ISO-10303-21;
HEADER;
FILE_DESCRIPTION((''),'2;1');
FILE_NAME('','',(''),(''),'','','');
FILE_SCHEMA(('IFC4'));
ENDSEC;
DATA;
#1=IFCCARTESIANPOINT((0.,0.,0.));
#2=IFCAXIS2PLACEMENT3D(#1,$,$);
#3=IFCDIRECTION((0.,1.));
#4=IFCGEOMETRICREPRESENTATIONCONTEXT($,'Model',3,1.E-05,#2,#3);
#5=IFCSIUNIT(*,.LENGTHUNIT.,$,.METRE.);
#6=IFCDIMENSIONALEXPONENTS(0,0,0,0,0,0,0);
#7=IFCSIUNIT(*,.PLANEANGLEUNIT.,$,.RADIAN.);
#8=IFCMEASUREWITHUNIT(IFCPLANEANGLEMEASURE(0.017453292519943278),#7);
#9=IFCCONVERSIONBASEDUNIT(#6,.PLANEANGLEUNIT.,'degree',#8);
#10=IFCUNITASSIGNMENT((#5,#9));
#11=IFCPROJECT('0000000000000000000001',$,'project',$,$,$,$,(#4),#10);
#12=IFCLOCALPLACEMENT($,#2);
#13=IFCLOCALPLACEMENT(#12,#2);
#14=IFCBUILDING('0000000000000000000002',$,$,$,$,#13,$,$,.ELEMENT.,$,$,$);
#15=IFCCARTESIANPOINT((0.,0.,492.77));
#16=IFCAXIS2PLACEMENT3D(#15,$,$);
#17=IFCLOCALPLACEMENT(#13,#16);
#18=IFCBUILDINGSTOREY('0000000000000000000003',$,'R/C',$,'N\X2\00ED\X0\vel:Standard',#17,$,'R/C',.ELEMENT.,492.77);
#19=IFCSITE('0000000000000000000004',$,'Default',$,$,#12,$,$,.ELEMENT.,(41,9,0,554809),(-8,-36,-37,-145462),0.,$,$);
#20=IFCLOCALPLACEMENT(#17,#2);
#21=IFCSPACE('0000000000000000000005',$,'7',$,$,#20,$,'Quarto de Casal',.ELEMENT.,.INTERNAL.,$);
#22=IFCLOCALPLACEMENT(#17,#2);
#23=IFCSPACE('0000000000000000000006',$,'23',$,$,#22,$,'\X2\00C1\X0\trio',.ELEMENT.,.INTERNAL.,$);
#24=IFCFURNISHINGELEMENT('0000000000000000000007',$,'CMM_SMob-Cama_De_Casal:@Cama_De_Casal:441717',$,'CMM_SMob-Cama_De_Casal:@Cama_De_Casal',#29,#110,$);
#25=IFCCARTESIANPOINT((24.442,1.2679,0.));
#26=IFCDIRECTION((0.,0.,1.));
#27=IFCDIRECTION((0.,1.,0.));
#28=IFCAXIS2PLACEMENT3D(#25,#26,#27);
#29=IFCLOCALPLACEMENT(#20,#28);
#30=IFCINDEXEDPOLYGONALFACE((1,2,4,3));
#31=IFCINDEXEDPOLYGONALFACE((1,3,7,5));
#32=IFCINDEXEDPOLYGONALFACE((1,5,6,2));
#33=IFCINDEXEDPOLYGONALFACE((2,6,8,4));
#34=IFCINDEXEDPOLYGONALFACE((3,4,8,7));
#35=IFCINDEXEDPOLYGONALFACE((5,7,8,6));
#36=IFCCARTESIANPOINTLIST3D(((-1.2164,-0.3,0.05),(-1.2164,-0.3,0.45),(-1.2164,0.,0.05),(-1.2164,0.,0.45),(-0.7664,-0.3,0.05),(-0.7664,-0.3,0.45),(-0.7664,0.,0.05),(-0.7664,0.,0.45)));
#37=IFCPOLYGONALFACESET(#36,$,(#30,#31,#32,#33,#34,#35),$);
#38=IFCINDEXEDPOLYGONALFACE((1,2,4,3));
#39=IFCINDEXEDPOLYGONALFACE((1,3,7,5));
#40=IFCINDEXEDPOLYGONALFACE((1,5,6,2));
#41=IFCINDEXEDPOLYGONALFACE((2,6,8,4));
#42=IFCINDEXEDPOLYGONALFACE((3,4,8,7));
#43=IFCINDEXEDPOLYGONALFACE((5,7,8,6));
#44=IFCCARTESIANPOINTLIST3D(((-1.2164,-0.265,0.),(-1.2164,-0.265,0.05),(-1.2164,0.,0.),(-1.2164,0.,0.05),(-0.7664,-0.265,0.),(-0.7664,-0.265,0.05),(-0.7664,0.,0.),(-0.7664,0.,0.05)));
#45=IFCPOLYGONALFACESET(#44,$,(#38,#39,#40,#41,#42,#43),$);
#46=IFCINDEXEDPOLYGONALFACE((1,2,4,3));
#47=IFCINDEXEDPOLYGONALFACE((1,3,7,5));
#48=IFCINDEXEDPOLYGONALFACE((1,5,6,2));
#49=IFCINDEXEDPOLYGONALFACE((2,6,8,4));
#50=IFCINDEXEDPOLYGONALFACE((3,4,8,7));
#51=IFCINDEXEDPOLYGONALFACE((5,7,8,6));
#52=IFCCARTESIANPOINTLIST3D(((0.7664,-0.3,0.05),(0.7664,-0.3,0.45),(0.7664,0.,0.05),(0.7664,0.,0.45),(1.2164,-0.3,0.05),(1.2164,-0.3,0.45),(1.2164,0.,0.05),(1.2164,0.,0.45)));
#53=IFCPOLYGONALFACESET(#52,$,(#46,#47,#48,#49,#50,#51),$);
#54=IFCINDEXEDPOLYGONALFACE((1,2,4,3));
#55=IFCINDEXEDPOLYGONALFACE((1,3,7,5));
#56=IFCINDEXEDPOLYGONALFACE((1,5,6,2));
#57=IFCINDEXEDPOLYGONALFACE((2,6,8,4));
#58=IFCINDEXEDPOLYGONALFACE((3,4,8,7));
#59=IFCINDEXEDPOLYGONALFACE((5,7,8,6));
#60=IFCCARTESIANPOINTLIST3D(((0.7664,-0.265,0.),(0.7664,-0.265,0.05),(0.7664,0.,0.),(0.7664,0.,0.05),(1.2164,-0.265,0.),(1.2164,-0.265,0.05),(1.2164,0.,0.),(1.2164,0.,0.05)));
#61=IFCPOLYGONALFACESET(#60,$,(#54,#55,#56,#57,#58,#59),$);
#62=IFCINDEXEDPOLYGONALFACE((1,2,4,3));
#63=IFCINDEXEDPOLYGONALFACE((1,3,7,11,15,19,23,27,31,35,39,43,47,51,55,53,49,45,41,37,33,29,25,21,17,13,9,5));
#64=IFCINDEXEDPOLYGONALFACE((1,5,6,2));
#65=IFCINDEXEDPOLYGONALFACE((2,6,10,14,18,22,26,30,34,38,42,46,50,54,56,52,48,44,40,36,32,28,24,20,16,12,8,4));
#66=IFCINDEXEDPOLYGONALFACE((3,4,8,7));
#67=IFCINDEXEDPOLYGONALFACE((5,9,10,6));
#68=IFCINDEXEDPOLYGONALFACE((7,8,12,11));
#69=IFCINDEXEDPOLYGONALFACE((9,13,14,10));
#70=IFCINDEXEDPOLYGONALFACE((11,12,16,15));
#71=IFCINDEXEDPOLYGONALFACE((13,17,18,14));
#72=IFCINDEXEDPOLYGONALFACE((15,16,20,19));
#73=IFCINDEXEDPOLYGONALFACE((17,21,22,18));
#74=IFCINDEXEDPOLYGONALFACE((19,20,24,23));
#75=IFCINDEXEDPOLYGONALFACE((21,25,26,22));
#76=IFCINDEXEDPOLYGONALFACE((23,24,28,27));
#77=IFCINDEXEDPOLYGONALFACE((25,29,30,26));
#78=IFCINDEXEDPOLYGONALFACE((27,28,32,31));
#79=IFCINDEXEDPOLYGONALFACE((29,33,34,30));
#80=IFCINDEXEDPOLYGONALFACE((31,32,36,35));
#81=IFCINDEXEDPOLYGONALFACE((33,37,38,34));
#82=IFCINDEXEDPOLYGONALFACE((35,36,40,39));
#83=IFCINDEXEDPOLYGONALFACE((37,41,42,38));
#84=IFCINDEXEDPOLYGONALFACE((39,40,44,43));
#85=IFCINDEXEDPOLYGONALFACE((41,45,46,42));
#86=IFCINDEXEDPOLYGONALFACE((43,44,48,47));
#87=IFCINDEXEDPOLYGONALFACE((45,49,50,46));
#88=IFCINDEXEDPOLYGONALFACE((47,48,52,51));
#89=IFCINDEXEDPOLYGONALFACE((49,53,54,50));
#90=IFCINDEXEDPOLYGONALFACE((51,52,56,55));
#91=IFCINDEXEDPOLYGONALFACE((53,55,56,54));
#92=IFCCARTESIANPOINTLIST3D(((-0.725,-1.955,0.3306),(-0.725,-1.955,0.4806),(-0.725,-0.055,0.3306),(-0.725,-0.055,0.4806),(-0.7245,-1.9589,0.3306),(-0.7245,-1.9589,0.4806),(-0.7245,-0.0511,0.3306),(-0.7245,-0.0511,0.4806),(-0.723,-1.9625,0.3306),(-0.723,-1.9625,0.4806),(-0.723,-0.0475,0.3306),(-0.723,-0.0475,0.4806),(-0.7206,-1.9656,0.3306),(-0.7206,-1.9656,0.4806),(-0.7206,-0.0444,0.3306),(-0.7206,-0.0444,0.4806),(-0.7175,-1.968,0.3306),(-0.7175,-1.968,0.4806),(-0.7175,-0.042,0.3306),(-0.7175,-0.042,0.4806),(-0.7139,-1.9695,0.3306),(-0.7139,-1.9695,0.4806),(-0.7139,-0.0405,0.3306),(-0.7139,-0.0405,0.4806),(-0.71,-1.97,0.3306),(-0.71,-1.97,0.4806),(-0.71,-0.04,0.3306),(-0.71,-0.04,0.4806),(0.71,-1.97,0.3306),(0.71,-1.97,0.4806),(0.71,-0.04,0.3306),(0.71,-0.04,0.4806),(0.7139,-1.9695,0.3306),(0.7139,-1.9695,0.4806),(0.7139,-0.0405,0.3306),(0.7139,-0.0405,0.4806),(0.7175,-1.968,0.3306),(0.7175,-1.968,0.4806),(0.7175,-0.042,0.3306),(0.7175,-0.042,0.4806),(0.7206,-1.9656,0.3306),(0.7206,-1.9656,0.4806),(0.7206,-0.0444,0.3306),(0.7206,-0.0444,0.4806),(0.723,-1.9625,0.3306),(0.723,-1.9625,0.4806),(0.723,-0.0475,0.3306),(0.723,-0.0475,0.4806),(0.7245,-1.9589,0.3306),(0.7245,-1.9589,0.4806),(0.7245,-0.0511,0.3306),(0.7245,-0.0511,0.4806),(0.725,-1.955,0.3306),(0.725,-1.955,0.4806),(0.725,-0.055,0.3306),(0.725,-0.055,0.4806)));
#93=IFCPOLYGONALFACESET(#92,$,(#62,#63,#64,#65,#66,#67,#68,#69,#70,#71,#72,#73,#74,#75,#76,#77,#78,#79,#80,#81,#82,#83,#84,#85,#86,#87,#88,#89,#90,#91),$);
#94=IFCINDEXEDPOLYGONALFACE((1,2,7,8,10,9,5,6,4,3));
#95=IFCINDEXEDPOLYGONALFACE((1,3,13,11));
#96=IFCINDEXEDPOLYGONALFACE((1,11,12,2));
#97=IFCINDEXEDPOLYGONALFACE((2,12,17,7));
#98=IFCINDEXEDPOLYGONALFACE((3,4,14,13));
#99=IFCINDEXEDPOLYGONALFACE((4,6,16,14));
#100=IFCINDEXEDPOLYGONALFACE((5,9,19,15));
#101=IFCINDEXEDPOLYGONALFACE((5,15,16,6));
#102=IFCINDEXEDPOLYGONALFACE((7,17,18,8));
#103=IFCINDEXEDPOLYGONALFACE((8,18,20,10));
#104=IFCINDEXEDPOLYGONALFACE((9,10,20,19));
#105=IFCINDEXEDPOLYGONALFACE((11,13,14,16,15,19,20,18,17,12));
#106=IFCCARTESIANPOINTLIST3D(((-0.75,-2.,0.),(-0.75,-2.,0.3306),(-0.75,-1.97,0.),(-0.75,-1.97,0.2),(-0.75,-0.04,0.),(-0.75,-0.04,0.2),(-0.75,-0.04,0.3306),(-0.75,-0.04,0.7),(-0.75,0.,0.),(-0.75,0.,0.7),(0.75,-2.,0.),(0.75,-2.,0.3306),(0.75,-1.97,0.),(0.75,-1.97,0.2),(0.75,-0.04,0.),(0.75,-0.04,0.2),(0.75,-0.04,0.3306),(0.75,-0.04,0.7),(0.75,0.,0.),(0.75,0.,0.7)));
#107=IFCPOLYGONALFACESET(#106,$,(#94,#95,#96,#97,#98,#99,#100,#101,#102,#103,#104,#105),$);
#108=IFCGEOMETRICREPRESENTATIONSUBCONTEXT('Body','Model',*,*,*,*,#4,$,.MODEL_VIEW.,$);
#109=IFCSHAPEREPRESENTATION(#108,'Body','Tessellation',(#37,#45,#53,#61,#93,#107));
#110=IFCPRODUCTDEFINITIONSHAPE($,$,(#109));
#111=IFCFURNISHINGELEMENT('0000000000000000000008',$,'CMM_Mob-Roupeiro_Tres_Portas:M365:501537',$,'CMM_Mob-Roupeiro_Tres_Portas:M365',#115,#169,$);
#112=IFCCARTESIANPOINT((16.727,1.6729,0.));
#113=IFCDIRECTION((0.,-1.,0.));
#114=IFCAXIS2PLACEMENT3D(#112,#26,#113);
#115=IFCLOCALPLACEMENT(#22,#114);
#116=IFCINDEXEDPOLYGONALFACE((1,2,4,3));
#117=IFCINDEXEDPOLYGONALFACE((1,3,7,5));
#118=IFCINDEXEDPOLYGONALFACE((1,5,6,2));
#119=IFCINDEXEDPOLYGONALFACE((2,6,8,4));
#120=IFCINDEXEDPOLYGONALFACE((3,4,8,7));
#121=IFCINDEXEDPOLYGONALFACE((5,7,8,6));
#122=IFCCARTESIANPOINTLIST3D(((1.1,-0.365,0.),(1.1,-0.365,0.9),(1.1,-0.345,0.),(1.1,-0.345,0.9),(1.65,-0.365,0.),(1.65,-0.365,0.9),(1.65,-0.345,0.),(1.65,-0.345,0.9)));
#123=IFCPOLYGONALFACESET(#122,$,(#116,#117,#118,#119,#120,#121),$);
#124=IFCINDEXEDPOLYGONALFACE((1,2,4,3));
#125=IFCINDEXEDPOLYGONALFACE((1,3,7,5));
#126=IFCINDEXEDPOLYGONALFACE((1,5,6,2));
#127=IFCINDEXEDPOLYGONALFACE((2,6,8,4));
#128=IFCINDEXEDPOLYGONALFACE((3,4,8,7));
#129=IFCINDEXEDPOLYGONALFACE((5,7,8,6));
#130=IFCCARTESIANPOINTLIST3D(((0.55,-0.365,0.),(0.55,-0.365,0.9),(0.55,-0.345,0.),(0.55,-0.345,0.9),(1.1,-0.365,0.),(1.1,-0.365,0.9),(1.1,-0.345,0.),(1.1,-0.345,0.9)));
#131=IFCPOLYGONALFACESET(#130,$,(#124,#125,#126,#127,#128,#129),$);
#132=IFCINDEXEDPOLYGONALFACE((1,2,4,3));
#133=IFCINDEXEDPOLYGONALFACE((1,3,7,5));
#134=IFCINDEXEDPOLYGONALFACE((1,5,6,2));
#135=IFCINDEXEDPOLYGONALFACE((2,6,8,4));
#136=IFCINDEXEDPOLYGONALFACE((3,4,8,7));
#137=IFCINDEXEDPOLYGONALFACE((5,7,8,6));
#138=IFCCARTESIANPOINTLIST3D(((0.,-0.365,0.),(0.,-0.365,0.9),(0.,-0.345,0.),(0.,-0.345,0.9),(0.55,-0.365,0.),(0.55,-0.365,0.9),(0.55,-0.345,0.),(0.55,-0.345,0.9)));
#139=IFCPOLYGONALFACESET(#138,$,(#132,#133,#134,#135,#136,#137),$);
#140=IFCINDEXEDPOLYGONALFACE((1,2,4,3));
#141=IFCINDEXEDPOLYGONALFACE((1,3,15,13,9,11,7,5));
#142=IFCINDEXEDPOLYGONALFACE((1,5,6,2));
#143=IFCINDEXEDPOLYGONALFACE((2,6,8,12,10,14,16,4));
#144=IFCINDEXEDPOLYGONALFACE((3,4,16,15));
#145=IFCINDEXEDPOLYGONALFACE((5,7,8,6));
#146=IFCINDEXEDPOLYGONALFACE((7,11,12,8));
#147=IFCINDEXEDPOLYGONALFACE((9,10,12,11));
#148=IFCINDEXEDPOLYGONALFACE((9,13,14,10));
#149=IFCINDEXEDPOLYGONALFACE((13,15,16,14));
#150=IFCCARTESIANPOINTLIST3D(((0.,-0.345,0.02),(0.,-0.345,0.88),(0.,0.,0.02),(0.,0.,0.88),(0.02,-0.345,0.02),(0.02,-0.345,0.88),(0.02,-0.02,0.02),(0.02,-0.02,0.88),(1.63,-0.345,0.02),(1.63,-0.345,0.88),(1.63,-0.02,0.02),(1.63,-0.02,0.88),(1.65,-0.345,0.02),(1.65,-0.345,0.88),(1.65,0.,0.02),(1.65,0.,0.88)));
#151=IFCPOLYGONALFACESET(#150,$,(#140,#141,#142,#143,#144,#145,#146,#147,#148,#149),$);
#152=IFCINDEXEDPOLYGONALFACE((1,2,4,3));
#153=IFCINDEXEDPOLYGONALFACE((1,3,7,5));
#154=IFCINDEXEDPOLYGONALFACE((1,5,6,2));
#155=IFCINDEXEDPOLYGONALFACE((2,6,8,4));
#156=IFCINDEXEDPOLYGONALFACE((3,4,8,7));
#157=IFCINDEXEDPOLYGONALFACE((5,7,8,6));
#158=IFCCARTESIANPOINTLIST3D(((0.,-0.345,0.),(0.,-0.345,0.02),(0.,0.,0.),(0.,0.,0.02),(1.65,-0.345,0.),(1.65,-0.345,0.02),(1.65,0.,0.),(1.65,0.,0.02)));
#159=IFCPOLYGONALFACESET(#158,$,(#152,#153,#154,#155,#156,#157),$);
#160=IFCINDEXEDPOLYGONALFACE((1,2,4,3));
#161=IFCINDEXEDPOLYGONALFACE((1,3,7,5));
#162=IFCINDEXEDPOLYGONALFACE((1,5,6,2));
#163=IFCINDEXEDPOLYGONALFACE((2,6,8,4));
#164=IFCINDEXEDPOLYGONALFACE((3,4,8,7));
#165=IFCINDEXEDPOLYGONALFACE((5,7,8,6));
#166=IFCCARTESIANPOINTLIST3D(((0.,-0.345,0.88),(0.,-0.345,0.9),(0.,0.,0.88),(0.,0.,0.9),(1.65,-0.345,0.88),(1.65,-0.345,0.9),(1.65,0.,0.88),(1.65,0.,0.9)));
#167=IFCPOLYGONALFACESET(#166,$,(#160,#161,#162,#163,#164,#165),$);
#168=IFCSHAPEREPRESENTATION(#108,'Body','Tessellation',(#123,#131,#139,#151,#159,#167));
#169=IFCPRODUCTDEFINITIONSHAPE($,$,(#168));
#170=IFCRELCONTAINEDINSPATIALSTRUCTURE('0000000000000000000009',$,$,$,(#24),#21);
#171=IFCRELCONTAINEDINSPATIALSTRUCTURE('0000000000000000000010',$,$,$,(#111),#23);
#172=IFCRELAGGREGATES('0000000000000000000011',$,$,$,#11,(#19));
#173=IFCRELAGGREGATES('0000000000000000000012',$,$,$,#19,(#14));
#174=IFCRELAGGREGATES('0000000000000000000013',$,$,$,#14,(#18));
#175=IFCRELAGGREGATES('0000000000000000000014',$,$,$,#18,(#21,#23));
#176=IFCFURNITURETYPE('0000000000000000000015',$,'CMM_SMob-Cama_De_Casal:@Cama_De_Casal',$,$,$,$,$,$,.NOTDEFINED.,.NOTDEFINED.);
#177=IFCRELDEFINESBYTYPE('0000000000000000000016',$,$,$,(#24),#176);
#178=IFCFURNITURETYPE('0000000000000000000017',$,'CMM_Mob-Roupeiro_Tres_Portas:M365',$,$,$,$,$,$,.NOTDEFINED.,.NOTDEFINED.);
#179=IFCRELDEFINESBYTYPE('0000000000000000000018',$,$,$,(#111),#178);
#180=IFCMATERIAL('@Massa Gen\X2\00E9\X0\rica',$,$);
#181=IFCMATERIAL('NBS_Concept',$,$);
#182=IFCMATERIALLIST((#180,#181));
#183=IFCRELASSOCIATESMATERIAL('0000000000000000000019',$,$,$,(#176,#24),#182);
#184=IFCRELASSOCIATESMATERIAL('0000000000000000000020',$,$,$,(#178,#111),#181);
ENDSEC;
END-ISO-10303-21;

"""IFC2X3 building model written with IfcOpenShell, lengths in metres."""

from ifc_helpers import new_model, entity, si_unit, converted_unit, direction, frame, frame_2d, origin, origin_2d_with_axis, place, context, subcontext, project, spatial, polyline, circle_curve, parameter, trimmed, segment, composite_curve, rectangle, outline, extrude, source, transform, mapped, material, material_list, type_object, type_shapes, element, save


model = new_model("IFC2X3")

# Units and contexts
model_context = context("Model", 3, precision=1e-05, world=origin(), true_north=direction((0.0, 1.0)))
body_context = subcontext(model_context, "Body", "Model", "MODEL_VIEW")
ifc_project = project(units=[si_unit("LENGTHUNIT", "METRE"), converted_unit("PLANEANGLEUNIT", "degree", entity("IfcPlaneAngleMeasure", 0.017453292519943278), si_unit("PLANEANGLEUNIT", "RADIAN"), dimensions=[0, 0, 0, 0, 0, 0, 0])], contexts=[model_context])

# Site, building, storey
site_placement = place(None, origin())
site = spatial("IfcSite", under=ifc_project, at=site_placement, Name="Default", CompositionType="ELEMENT", RefLatitude=(41, 9, 0, 554809), RefLongitude=(-8, -36, -37, -145462), RefElevation=0.0)
building_placement = place(site_placement, origin())
building = spatial("IfcBuilding", under=site, at=building_placement, CompositionType="ELEMENT")
storey_placement = place(building_placement, frame((0.0, 0.0, 492.77)))
storey = spatial("IfcBuildingStorey", under=building, at=storey_placement, Name="R/C", ObjectType="Nível:Standard", LongName="R/C", CompositionType="ELEMENT", Elevation=492.77)

# Shared definitions
ifc_material_1 = material(Name="NBS_Concept")

# Shared definitions
space_1_placement = place(storey_placement, origin())
space_1 = spatial("IfcSpace", under=storey, at=space_1_placement, Name="7", LongName="Quarto de Casal", CompositionType="ELEMENT", InteriorOrExteriorSpace="INTERNAL")

# Furnishing element
ifc_material_2 = material(Name="@Massa Genérica")
ifc_material_list = material_list([ifc_material_2, ifc_material_1])
furniture_type_1 = type_object("IfcFurnitureType", Name="CMM_SMob-Cama_De_Casal:@Cama_De_Casal", AssemblyPlace="NOTDEFINED", material=ifc_material_list)
shared_shape_1 = source(origin(), body_context, "Body", "SweptSolid", [
    extrude(rectangle(XDim=0.3, YDim=0.45, at=frame_2d((0.0, 0.0), x_axis=(1.0, 0.0))), frame((-0.9914, -0.15, 0.05), z_axis=(0.0, 0.0, 1.0), x_axis=(0.0, 1.0, 0.0)), (0.0, 0.0, 1.0), 0.4),
    extrude(rectangle(XDim=0.265, YDim=0.45, at=frame_2d((0.0, 0.0), x_axis=(1.0, 0.0))), frame((-0.9914, -0.1325, 0.0), z_axis=(0.0, 0.0, 1.0), x_axis=(0.0, -1.0, 0.0)), (0.0, 0.0, 1.0), 0.05),
    extrude(rectangle(XDim=0.45, YDim=0.3, at=frame_2d((0.0, 0.0), x_axis=(1.0, 0.0))), frame((0.9914, -0.15, 0.05)), (0.0, 0.0, 1.0), 0.4),
    extrude(rectangle(XDim=0.45, YDim=0.265, at=origin_2d_with_axis()), frame((0.9914, -0.1325, 0.0), z_axis=(0.0, 0.0, 1.0), x_axis=(-1.0, 0.0, 0.0)), (0.0, 0.0, 1.0), 0.05),
    extrude(outline(composite_curve([segment(polyline([(-0.71, -0.965), (0.71, -0.965)]), True, "CONTINUOUS"), segment(trimmed(circle_curve(frame_2d((0.71, -0.95), x_axis=(-1.0, 0.0)), 0.015), [parameter(90.0)], [parameter(180.0)], True, "PARAMETER"), True, "CONTINUOUS"), segment(polyline([(0.725, -0.95), (0.725, 0.95)]), True, "CONTINUOUS"), segment(trimmed(circle_curve(frame_2d((0.71, 0.95), x_axis=(-1.0, 0.0)), 0.015), [parameter(180.0)], [parameter(270.0)], True, "PARAMETER"), True, "CONTINUOUS"), segment(polyline([(0.71, 0.965), (-0.71, 0.965)]), True, "CONTINUOUS"), segment(trimmed(circle_curve(frame_2d((-0.71, 0.95), x_axis=(-1.0, 0.0)), 0.015), [parameter(270.0)], [parameter(0.0)], True, "PARAMETER"), True, "CONTINUOUS"), segment(polyline([(-0.725, 0.95), (-0.725, -0.95)]), True, "CONTINUOUS"), segment(trimmed(circle_curve(frame_2d((-0.71, -0.95), x_axis=(-1.0, 0.0)), 0.015), [parameter(0.0)], [parameter(90.0)], True, "PARAMETER"), True, "CONTINUOUS")], self_intersect=False)), frame((0.0, -1.005, 0.3306), z_axis=(0.0, 0.0, 1.0), x_axis=(-1.0, 0.0, 0.0)), (0.0, 0.0, 1.0), 0.15),
    extrude(outline(polyline([(-0.2461, -1.16), (-0.2461, -1.19), (0.0845, -1.19), (0.0845, 0.77), (0.4539, 0.77), (0.4539, 0.81), (-0.2461, 0.81), (-0.2461, 0.77), (-0.0461, 0.77), (-0.0461, -1.16), (-0.2461, -1.16)])), frame((-0.75, -0.81, 0.2461), z_axis=(-1.0, 0.0, 0.0), x_axis=(0.0, 0.0, 1.0)), (0.0, 0.0, -1.0), 1.5),
])
type_shapes(furniture_type_1, [shared_shape_1])
furnishing_1_placement = place(space_1_placement, frame((24.442, 1.2679, 0.0), z_axis=(0.0, 0.0, 1.0), x_axis=(0.0, 1.0, 0.0)))
element("IfcFurnishingElement", 1, at=furnishing_1_placement, inside=space_1, type_object=furniture_type_1, material=ifc_material_list, Name="CMM_SMob-Cama_De_Casal:@Cama_De_Casal:441717", ObjectType="CMM_SMob-Cama_De_Casal:@Cama_De_Casal", context=body_context, shape_type="MappedRepresentation", body=[
    mapped(shared_shape_1, transform((0.0, 0.0, 0.0), scale=1.0)),
])

# Shared definitions
space_2_placement = place(storey_placement, origin())
space_2 = spatial("IfcSpace", under=storey, at=space_2_placement, Name="23", LongName="Átrio", CompositionType="ELEMENT", InteriorOrExteriorSpace="INTERNAL")

# Furnishing element
furniture_type_2 = type_object("IfcFurnitureType", Name="CMM_Mob-Roupeiro_Tres_Portas:M365", AssemblyPlace="NOTDEFINED", material=ifc_material_1)
shared_shape_2 = source(origin(), body_context, "Body", "SweptSolid", [
    extrude(rectangle(XDim=0.02, YDim=0.55, at=frame_2d((0.0, 0.0), x_axis=(1.0, 0.0))), frame((1.375, -0.355, 0.0), z_axis=(0.0, 0.0, 1.0), x_axis=(0.0, 1.0, 0.0)), (0.0, 0.0, 1.0), 0.9),
    extrude(rectangle(XDim=0.02, YDim=0.55, at=frame_2d((0.0, 0.0), x_axis=(1.0, 0.0))), frame((0.825, -0.355, 0.0), z_axis=(0.0, 0.0, 1.0), x_axis=(0.0, 1.0, 0.0)), (0.0, 0.0, 1.0), 0.9),
    extrude(rectangle(XDim=0.02, YDim=0.55, at=frame_2d((0.0, 0.0), x_axis=(1.0, 0.0))), frame((0.275, -0.355, 0.0), z_axis=(0.0, 0.0, 1.0), x_axis=(0.0, 1.0, 0.0)), (0.0, 0.0, 1.0), 0.9),
    extrude(outline(polyline([(-0.1775, -0.825), (0.1675, -0.825), (0.1675, -0.805), (-0.1575, -0.805), (-0.1575, 0.805), (0.1675, 0.805), (0.1675, 0.825), (-0.1775, 0.825), (-0.1775, -0.825)])), frame((0.825, -0.1775, 0.02), z_axis=(0.0, 0.0, 1.0), x_axis=(0.0, -1.0, 0.0)), (0.0, 0.0, 1.0), 0.86),
    extrude(rectangle(XDim=0.345, YDim=1.65, at=origin_2d_with_axis()), frame((0.825, -0.1725, 0.0), z_axis=(0.0, 0.0, 1.0), x_axis=(0.0, 1.0, 0.0)), (0.0, 0.0, 1.0), 0.02),
    extrude(rectangle(XDim=0.345, YDim=1.65, at=origin_2d_with_axis()), frame((0.825, -0.1725, 0.88), z_axis=(0.0, 0.0, 1.0), x_axis=(0.0, 1.0, 0.0)), (0.0, 0.0, 1.0), 0.02),
])
type_shapes(furniture_type_2, [shared_shape_2])
furnishing_2_placement = place(space_2_placement, frame((16.727, 1.6729, 0.0), z_axis=(0.0, 0.0, 1.0), x_axis=(0.0, -1.0, 0.0)))
element("IfcFurnishingElement", 2, at=furnishing_2_placement, inside=space_2, type_object=furniture_type_2, material=ifc_material_1, Name="CMM_Mob-Roupeiro_Tres_Portas:M365:501537", ObjectType="CMM_Mob-Roupeiro_Tres_Portas:M365", context=body_context, shape_type="MappedRepresentation", body=[
    mapped(shared_shape_2, transform((0.0, 0.0, 0.0), scale=1.0)),
])

save(model, "model.ifc")
